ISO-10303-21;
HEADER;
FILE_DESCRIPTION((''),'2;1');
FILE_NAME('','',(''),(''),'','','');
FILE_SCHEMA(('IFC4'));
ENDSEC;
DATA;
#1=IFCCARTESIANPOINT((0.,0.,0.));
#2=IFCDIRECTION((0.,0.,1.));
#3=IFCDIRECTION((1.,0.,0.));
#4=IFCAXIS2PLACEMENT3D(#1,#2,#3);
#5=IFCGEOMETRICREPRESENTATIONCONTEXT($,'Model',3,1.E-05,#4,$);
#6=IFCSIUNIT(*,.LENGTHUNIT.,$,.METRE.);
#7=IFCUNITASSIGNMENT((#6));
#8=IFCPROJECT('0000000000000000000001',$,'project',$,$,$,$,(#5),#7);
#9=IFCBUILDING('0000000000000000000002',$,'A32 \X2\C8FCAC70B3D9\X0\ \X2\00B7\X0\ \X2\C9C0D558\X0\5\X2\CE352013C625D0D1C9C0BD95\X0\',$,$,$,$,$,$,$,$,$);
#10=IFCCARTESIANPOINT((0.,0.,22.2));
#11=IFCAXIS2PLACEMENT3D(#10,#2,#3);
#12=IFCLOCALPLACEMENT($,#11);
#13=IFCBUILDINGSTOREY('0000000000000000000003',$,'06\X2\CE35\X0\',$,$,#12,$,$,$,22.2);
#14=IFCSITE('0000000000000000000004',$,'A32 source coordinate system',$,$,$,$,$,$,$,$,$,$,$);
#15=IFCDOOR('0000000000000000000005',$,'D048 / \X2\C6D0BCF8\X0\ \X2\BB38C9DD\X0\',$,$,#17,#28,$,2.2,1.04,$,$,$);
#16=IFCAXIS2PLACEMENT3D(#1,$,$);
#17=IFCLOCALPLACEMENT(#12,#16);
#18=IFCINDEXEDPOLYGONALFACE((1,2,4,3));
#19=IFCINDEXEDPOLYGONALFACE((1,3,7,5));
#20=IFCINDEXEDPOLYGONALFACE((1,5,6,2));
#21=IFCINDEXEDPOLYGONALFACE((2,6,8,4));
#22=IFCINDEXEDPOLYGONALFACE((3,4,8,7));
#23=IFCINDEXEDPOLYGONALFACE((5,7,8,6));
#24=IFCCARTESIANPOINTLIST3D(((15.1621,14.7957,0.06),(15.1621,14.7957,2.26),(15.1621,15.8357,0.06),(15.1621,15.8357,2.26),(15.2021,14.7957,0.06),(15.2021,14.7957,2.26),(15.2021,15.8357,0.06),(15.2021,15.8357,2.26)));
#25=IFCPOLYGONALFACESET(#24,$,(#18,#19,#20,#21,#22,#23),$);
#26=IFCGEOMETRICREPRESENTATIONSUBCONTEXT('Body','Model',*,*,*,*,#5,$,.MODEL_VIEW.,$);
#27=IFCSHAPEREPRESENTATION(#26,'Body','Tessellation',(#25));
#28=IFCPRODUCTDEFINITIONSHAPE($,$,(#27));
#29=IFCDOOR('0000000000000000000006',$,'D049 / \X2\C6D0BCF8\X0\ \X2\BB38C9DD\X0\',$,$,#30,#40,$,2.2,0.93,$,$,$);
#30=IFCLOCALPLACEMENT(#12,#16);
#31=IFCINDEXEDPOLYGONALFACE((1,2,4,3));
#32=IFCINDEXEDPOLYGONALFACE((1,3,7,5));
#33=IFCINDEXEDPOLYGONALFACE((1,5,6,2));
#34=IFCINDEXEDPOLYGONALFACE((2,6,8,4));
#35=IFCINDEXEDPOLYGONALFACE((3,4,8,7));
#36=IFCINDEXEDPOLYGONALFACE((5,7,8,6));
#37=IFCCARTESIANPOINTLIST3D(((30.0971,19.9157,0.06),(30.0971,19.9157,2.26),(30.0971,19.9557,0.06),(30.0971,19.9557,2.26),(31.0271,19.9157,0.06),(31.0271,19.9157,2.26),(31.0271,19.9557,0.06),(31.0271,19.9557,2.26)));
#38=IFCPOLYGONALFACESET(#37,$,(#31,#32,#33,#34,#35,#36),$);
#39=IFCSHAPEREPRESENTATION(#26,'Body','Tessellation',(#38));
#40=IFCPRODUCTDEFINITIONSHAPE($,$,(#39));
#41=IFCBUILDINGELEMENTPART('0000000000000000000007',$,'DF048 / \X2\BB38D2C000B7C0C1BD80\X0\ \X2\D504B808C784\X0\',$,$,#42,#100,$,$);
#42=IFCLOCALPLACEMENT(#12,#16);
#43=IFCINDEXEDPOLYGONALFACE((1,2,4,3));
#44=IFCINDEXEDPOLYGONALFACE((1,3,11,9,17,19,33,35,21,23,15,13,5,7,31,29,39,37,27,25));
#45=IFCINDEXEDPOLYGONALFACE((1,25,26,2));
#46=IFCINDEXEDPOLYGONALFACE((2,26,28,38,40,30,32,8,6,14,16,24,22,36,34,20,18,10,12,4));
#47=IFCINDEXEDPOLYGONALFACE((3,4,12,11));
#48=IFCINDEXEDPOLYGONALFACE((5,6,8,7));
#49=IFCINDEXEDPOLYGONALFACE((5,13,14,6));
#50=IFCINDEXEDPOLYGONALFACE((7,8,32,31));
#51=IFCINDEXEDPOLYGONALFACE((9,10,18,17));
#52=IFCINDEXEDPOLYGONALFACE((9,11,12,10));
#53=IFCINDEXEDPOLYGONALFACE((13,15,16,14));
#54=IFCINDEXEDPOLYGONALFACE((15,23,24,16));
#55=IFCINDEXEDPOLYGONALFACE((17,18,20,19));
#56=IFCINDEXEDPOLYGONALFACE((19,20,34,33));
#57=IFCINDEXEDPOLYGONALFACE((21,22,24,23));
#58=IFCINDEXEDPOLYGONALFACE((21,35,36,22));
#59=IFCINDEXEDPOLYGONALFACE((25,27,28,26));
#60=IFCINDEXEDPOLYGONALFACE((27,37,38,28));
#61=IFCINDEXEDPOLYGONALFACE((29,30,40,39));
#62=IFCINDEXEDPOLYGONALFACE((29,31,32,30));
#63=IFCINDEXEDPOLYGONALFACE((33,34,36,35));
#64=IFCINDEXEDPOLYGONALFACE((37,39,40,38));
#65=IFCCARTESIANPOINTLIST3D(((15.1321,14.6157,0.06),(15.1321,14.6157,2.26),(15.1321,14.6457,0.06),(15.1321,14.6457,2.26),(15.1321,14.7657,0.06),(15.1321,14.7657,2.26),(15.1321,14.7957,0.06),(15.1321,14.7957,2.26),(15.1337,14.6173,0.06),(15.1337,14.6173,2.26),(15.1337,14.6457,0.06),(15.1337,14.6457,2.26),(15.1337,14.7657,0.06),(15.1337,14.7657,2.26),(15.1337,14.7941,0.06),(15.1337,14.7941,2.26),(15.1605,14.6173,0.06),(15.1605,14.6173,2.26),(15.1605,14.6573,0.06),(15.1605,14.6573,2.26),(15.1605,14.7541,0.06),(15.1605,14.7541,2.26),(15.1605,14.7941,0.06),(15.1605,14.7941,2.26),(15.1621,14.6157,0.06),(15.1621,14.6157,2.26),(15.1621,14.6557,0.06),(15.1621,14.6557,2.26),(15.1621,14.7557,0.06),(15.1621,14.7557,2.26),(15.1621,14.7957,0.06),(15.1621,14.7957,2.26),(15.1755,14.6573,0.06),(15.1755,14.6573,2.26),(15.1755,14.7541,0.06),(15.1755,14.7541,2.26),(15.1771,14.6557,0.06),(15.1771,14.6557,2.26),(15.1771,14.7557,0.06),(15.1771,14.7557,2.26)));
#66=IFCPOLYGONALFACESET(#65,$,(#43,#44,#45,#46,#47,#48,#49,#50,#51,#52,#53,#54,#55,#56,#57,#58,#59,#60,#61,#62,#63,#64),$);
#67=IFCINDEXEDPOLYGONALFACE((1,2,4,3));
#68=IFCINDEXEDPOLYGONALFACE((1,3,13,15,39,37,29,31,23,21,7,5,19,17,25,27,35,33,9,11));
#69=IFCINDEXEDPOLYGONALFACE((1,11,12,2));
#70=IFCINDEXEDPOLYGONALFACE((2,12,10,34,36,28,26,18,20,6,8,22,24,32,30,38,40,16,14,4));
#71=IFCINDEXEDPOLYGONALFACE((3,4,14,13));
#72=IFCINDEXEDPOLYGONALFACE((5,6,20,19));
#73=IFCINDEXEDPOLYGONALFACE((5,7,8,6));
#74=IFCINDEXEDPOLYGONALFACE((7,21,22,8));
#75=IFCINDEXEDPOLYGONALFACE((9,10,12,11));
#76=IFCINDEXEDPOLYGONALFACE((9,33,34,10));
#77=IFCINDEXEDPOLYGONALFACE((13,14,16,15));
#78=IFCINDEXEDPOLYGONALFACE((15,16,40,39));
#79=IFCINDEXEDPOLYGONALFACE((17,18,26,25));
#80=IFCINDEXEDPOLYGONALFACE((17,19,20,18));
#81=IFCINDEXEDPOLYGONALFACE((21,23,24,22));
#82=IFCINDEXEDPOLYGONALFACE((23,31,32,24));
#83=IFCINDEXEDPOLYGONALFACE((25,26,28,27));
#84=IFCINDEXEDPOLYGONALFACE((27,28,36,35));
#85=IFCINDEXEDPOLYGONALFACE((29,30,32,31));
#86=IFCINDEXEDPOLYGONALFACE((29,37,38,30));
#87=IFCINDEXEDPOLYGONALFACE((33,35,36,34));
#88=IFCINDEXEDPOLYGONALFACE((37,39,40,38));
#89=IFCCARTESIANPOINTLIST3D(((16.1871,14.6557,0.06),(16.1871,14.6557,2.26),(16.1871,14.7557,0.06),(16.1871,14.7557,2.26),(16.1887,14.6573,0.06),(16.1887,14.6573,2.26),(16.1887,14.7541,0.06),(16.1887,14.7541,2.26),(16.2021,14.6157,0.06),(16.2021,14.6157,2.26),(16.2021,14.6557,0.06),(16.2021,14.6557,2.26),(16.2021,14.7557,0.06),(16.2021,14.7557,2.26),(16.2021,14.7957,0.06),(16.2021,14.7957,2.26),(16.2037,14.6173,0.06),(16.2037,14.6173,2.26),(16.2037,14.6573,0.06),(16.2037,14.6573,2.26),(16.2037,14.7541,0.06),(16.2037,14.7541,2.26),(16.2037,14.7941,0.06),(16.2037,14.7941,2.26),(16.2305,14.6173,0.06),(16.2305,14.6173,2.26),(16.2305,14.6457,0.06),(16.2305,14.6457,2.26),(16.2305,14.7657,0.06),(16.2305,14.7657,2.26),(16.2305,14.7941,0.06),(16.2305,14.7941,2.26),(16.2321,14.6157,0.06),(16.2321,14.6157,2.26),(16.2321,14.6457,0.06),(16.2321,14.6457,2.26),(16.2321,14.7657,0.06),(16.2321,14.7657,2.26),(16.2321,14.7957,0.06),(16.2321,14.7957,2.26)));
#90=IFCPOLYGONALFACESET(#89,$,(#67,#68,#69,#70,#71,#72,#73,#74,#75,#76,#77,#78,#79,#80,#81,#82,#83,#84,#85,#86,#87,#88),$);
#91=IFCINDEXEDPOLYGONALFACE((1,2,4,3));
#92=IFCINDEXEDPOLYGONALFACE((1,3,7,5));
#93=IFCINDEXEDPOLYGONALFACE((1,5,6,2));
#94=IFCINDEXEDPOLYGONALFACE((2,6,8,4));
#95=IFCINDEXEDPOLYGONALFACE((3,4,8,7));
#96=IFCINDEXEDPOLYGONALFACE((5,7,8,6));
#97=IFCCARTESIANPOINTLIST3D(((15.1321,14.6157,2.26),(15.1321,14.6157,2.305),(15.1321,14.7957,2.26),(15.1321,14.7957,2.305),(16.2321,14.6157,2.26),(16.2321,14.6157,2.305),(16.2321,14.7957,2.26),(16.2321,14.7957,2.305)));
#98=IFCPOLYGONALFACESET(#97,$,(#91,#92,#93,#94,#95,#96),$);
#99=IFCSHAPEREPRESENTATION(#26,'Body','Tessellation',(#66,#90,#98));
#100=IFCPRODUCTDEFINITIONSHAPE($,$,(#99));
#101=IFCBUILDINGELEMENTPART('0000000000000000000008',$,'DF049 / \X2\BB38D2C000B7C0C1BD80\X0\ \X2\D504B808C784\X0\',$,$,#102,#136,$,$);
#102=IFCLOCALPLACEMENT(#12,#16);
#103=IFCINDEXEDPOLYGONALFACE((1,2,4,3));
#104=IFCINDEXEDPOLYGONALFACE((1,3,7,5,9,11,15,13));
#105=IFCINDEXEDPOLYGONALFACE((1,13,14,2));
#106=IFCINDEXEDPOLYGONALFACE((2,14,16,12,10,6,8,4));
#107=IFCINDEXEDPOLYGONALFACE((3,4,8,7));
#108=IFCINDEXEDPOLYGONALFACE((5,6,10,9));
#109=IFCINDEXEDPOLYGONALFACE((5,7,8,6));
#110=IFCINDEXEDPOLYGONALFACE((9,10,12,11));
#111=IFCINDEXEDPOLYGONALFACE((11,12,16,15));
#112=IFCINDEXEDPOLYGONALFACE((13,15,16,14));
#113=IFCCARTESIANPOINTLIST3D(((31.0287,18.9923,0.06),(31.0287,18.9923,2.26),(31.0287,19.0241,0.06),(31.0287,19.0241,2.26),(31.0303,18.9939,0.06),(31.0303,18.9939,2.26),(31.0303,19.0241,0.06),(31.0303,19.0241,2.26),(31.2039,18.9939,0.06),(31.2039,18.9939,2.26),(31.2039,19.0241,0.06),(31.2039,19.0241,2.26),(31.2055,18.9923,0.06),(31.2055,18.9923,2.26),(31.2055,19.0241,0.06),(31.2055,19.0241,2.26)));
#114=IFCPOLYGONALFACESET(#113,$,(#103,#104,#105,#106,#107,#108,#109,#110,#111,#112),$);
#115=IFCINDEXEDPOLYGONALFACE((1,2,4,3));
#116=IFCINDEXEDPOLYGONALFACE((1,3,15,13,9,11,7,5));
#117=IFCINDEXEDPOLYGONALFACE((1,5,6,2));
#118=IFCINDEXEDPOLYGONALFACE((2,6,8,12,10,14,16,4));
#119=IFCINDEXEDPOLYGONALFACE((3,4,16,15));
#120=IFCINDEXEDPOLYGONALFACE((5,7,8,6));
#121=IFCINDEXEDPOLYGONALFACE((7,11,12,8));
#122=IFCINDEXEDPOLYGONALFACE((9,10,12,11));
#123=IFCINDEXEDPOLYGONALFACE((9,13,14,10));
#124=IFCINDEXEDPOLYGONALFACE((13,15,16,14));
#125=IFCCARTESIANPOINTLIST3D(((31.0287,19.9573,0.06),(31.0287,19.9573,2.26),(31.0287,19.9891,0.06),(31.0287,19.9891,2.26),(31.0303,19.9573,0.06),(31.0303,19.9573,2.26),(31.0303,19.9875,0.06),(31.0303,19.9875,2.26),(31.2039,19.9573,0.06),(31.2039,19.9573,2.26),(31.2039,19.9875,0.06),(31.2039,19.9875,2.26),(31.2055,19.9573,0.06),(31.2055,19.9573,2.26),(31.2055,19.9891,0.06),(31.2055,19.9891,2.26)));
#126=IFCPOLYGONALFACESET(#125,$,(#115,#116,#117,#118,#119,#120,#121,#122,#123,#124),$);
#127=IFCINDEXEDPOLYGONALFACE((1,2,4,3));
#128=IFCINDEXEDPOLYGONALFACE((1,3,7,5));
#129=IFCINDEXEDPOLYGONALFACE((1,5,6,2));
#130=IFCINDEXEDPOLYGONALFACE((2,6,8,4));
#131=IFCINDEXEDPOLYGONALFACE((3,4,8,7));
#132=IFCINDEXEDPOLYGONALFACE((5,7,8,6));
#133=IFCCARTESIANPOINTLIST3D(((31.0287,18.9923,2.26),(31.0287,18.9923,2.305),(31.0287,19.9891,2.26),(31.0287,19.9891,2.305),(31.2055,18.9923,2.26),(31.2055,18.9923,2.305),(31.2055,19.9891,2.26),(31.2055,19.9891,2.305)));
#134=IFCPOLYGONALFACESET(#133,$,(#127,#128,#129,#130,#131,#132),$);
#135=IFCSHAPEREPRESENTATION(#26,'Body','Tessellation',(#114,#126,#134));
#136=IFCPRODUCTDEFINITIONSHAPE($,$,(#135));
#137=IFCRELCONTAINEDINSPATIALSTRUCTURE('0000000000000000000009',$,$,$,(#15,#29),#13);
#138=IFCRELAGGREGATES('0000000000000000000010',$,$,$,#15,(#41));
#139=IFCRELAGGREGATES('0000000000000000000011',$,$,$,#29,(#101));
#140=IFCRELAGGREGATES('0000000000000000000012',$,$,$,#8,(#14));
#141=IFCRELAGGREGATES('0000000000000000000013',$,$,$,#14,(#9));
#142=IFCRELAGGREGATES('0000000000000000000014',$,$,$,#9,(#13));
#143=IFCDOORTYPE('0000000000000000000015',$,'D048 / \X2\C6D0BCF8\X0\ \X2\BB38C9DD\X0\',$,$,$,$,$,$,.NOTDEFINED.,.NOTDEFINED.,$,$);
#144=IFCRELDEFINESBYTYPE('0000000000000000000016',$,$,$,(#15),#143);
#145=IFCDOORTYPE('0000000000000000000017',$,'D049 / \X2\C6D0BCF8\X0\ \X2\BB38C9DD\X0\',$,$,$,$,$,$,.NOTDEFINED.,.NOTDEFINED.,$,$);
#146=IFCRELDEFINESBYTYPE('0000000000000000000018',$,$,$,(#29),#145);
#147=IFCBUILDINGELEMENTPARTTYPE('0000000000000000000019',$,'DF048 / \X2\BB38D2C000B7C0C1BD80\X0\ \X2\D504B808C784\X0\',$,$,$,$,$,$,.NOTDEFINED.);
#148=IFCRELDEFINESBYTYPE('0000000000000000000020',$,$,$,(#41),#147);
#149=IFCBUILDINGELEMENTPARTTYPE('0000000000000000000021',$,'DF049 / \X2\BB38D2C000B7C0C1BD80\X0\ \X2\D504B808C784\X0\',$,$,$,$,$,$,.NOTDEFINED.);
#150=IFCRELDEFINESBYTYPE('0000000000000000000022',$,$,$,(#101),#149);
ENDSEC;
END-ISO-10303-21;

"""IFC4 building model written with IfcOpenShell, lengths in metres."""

from ifc_helpers import new_model, si_unit, frame, origin, origin_with_axes, place, context, subcontext, project, spatial, polyline, outline, extrude, source, transform, mapped, type_object, type_shapes, element, aggregate, save


model = new_model("IFC4")

# Units and contexts
model_context = context("Model", 3, precision=1e-05, world=origin_with_axes())
body_context = subcontext(model_context, "Body", "Model", "MODEL_VIEW")
ifc_project = project(units=[si_unit("LENGTHUNIT", "METRE")], contexts=[model_context])

# Site, building, storey
storey_placement = place(None, frame((0.0, 0.0, 22.2), z_axis=(0.0, 0.0, 1.0), x_axis=(1.0, 0.0, 0.0)))
site = spatial("IfcSite", under=ifc_project, Name="A32 source coordinate system")
building = spatial("IfcBuilding", under=site, Name="A32 주거동 · 지하5층–옥탑지붕")
storey = spatial("IfcBuildingStorey", under=building, at=storey_placement, Name="06층", Elevation=22.2)

# Doors
door_type_1 = type_object("IfcDoorType", Name="D048 / 원본 문짝", OperationType="NOTDEFINED", PredefinedType="NOTDEFINED")
shared_shape_1 = source(origin(), body_context, "Body", "SweptSolid", [
    extrude(outline(polyline([(15.2021, 15.8357), (15.2021, 14.7957), (15.1621, 14.7957), (15.1621, 15.8357), (15.2021, 15.8357)])), frame((0.0, 0.0, 0.06)), (0.0, 0.0, 1.0), 2.2),
])
type_shapes(door_type_1, [shared_shape_1])
door_1_placement = place(storey_placement, origin_with_axes())
door_1 = element("IfcDoor", 1, at=door_1_placement, inside=storey, type_object=door_type_1, Name="D048 / 원본 문짝", OverallHeight=2.2, OverallWidth=1.04, context=body_context, shape_type="MappedRepresentation", body=[
    mapped(shared_shape_1, transform((0.0, 0.0, 0.0), scale=1.0)),
])
door_type_2 = type_object("IfcDoorType", Name="D049 / 원본 문짝", OperationType="NOTDEFINED", PredefinedType="NOTDEFINED")
shared_shape_2 = source(origin(), body_context, "Body", "SweptSolid", [
    extrude(outline(polyline([(31.0271, 19.9557), (31.0271, 19.9157), (30.0971, 19.9157), (30.0971, 19.9557), (31.0271, 19.9557)])), frame((0.0, 0.0, 0.06)), (0.0, 0.0, 1.0), 2.2),
])
type_shapes(door_type_2, [shared_shape_2])
door_2_placement = place(storey_placement, origin_with_axes())
door_2 = element("IfcDoor", 2, at=door_2_placement, inside=storey, type_object=door_type_2, Name="D049 / 원본 문짝", OverallHeight=2.2, OverallWidth=0.93, context=body_context, shape_type="MappedRepresentation", body=[
    mapped(shared_shape_2, transform((0.0, 0.0, 0.0), scale=1.0)),
])

# Building element parts
building_element_part_type_1 = type_object("IfcBuildingElementPartType", Name="DF048 / 문틀·상부 프레임", PredefinedType="NOTDEFINED")
shared_shape_3 = source(origin(), body_context, "Body", "SweptSolid", [
    extrude(outline(polyline([(15.1321, 14.7657), (15.1321, 14.7957), (15.1621, 14.7957), (15.1621, 14.7557), (15.1771, 14.7557), (15.1771, 14.6557), (15.1621, 14.6557), (15.1621, 14.6157), (15.1321, 14.6157), (15.1321, 14.6457), (15.1337, 14.6457), (15.1337, 14.6173), (15.1605, 14.6173), (15.1605, 14.6573), (15.1755, 14.6573), (15.1755, 14.7541), (15.1605, 14.7541), (15.1605, 14.7941), (15.1337, 14.7941), (15.1337, 14.7657), (15.1321, 14.7657)])), frame((0.0, 0.0, 0.06)), (0.0, 0.0, 1.0), 2.2),
    extrude(outline(polyline([(16.2305, 14.7941), (16.2037, 14.7941), (16.2037, 14.7541), (16.1887, 14.7541), (16.1887, 14.6573), (16.2037, 14.6573), (16.2037, 14.6173), (16.2305, 14.6173), (16.2305, 14.6457), (16.2321, 14.6457), (16.2321, 14.6157), (16.2021, 14.6157), (16.2021, 14.6557), (16.1871, 14.6557), (16.1871, 14.7557), (16.2021, 14.7557), (16.2021, 14.7957), (16.2321, 14.7957), (16.2321, 14.7657), (16.2305, 14.7657), (16.2305, 14.7941)])), frame((0.0, 0.0, 0.06)), (0.0, 0.0, 1.0), 2.2),
    extrude(outline(polyline([(15.1321, 14.6157), (15.1321, 14.7957), (16.2321, 14.7957), (16.2321, 14.6157), (15.1321, 14.6157)])), frame((0.0, 0.0, 2.26)), (0.0, 0.0, 1.0), 0.045),
])
type_shapes(building_element_part_type_1, [shared_shape_3])
building_element_part_1_placement = place(door_1_placement, origin_with_axes())
building_element_part_1 = element("IfcBuildingElementPart", 3, at=building_element_part_1_placement, type_object=building_element_part_type_1, Name="DF048 / 문틀·상부 프레임", context=body_context, shape_type="MappedRepresentation", body=[
    mapped(shared_shape_3, transform((0.0, 0.0, 0.0), scale=1.0)),
])
aggregate(door_1, [building_element_part_1])
building_element_part_type_2 = type_object("IfcBuildingElementPartType", Name="DF049 / 문틀·상부 프레임", PredefinedType="NOTDEFINED")
shared_shape_4 = source(origin(), body_context, "Body", "SweptSolid", [
    extrude(outline(polyline([(31.0303, 19.0241), (31.0303, 18.9939), (31.2039, 18.9939), (31.2039, 19.0241), (31.2055, 19.0241), (31.2055, 18.9923), (31.0287, 18.9923), (31.0287, 19.0241), (31.0303, 19.0241)])), frame((0.0, 0.0, 0.06)), (0.0, 0.0, 1.0), 2.2),
    extrude(outline(polyline([(31.0287, 19.9891), (31.2055, 19.9891), (31.2055, 19.9573), (31.2039, 19.9573), (31.2039, 19.9875), (31.0303, 19.9875), (31.0303, 19.9573), (31.0287, 19.9573), (31.0287, 19.9891)])), frame((0.0, 0.0, 0.06)), (0.0, 0.0, 1.0), 2.2),
    extrude(outline(polyline([(31.0287, 18.9923), (31.0287, 19.9891), (31.2055, 19.9891), (31.2055, 18.9923), (31.0287, 18.9923)])), frame((0.0, 0.0, 2.26)), (0.0, 0.0, 1.0), 0.045),
])
type_shapes(building_element_part_type_2, [shared_shape_4])
building_element_part_2_placement = place(door_2_placement, origin_with_axes())
building_element_part_2 = element("IfcBuildingElementPart", 4, at=building_element_part_2_placement, type_object=building_element_part_type_2, Name="DF049 / 문틀·상부 프레임", context=body_context, shape_type="MappedRepresentation", body=[
    mapped(shared_shape_4, transform((0.0, 0.0, 0.0), scale=1.0)),
])
aggregate(door_2, [building_element_part_2])

save(model, "model.ifc")
